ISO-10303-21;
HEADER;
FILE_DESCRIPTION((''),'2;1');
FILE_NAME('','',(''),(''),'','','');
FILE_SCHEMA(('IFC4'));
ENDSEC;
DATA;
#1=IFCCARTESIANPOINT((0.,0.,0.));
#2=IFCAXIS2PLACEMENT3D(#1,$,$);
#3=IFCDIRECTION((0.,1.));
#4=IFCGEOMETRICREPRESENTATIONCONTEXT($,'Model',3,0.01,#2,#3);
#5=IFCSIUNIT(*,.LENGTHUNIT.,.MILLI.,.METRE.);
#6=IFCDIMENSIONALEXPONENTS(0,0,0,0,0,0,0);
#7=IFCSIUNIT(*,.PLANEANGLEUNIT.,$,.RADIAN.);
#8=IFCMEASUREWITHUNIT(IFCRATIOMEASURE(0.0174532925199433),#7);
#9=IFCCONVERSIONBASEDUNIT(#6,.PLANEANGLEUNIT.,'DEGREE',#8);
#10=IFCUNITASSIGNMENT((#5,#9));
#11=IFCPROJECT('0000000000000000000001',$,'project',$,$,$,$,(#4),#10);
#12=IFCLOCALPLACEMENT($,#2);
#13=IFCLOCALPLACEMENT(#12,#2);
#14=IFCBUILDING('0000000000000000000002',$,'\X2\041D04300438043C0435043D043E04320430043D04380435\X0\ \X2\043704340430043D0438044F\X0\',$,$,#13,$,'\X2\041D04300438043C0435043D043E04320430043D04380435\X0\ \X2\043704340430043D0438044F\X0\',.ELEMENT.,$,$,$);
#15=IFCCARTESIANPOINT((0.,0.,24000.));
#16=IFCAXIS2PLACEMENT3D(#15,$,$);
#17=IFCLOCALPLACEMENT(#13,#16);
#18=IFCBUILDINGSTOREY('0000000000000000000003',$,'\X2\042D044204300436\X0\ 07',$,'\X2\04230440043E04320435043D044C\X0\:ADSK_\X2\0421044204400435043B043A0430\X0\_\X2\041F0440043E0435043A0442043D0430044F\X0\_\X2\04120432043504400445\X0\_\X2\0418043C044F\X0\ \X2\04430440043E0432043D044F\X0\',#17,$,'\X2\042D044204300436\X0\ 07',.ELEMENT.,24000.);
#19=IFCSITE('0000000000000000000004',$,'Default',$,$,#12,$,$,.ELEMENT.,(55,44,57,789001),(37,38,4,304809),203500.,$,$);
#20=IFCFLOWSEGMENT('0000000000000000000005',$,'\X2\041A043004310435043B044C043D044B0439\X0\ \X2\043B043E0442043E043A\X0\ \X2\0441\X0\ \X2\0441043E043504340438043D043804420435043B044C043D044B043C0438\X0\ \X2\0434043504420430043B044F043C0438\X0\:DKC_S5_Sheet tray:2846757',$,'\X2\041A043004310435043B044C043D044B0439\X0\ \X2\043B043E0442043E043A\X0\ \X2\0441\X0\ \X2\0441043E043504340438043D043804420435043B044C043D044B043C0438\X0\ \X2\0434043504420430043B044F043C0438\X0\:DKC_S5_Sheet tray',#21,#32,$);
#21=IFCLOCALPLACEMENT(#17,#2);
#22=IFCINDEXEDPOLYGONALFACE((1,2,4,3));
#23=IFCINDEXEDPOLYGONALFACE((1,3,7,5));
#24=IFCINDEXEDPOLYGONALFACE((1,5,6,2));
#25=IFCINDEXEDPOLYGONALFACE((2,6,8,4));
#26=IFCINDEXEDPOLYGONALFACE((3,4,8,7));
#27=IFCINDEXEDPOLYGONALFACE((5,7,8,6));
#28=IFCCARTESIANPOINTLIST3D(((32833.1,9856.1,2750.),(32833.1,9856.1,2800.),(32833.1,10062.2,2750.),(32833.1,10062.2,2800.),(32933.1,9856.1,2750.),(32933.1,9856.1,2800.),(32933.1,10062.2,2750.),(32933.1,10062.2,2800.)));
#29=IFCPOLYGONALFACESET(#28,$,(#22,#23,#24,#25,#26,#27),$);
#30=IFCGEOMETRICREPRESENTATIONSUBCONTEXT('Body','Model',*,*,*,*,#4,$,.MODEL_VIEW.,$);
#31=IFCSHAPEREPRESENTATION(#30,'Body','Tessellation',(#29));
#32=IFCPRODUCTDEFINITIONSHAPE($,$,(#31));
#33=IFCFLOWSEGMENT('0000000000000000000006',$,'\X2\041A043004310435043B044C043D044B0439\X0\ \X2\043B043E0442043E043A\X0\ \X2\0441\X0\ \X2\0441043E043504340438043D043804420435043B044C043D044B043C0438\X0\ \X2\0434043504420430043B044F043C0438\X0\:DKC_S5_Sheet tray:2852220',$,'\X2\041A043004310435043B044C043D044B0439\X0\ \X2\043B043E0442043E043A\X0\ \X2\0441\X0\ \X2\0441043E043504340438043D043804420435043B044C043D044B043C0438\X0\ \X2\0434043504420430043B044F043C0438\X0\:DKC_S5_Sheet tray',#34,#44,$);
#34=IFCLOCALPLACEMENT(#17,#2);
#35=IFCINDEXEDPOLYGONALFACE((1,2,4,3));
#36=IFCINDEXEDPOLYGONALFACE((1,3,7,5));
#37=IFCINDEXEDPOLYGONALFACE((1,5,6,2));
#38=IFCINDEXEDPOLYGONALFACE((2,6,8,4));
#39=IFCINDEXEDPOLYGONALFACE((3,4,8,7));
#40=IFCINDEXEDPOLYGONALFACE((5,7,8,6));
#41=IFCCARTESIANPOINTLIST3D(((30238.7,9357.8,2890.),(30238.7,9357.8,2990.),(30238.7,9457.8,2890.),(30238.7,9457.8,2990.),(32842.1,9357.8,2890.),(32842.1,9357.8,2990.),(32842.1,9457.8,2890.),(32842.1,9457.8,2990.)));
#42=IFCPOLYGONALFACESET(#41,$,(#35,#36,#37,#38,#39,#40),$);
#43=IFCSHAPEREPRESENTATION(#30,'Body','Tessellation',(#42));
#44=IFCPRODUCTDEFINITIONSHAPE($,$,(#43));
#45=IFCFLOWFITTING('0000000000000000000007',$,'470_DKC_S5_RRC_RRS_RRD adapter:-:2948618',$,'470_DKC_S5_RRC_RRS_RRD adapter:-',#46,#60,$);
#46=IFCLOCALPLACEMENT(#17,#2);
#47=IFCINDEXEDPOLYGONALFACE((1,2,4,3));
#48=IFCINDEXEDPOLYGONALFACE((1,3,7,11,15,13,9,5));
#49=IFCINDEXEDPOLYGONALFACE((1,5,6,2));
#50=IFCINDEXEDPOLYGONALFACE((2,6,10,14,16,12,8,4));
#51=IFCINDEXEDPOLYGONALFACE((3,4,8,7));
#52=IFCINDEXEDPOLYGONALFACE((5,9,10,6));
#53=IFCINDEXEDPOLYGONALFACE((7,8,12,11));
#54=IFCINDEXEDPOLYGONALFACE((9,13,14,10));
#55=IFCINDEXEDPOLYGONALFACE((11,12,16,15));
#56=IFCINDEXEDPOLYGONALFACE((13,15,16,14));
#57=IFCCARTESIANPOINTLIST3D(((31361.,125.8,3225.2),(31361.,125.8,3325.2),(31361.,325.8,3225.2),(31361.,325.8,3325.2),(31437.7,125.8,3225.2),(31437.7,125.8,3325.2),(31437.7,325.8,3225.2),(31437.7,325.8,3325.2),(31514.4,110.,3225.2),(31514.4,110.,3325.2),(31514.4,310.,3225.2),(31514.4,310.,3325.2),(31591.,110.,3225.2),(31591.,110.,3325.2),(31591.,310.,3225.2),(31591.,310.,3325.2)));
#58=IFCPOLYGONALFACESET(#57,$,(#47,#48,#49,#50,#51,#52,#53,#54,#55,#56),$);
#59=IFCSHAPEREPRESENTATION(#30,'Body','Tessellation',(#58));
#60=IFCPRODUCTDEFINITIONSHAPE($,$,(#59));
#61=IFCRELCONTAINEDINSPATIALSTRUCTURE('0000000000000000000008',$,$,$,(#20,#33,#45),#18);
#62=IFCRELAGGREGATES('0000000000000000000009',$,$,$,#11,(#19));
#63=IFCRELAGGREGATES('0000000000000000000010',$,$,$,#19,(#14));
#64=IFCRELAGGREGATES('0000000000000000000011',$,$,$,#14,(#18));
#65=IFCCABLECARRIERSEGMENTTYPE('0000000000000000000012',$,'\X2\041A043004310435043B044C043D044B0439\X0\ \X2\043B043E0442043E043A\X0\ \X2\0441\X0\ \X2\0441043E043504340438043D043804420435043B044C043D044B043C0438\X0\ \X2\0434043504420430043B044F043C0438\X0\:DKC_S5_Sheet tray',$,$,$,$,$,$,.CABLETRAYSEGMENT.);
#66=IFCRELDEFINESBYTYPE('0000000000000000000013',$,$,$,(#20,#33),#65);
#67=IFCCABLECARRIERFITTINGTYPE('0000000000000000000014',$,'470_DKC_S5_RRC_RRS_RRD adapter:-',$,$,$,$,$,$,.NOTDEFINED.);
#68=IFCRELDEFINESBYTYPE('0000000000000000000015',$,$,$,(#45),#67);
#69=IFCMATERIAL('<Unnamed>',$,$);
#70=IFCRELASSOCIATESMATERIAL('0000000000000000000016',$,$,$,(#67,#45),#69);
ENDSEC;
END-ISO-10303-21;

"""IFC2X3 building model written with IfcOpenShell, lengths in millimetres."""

from ifc_helpers import new_model, entity, si_unit, converted_unit, direction, frame, frame_2d, origin, place, context, subcontext, project, spatial, polyline, rectangle, outline, extrude, source, transform, mapped, material, type_object, type_shapes, element, save


model = new_model("IFC2X3")

# Units and contexts
model_context = context("Model", 3, precision=0.01, world=origin(), true_north=direction((0.0, 1.0)))
body_context = subcontext(model_context, "Body", "Model", "MODEL_VIEW")
ifc_project = project(units=[si_unit("LENGTHUNIT", "METRE", prefix="MILLI"), converted_unit("PLANEANGLEUNIT", "DEGREE", entity("IfcRatioMeasure", 0.0174532925199433), si_unit("PLANEANGLEUNIT", "RADIAN"), dimensions=[0, 0, 0, 0, 0, 0, 0])], contexts=[model_context])

# Site, building, storey
site_placement = place(None, frame((0.0, 0.0, 0.0)))
site = spatial("IfcSite", under=ifc_project, at=site_placement, Name="Default", CompositionType="ELEMENT", RefLatitude=(55, 44, 57, 789001), RefLongitude=(37, 38, 4, 304809), RefElevation=203500.0)
building_placement = place(site_placement, origin())
building = spatial("IfcBuilding", under=site, at=building_placement, Name="Наименование здания", LongName="Наименование здания", CompositionType="ELEMENT")
storey_placement = place(building_placement, frame((0.0, 0.0, 24000.0)))
storey = spatial("IfcBuildingStorey", under=building, at=storey_placement, Name="Этаж 07", ObjectType="Уровень:ADSK_Стрелка_Проектная_Вверх_Имя уровня", LongName="Этаж 07", CompositionType="ELEMENT", Elevation=24000.0)

# Flow segments
cable_carrier_segment_type = type_object("IfcCableCarrierSegmentType", Name="Кабельный лоток с соединительными деталями:DKC_S5_Sheet tray", PredefinedType="CABLETRAYSEGMENT")
flow_segment_1_placement = place(storey_placement, frame((32833.1, 9856.1, 2750.0)))
element("IfcFlowSegment", 1, at=flow_segment_1_placement, inside=storey, type_object=cable_carrier_segment_type, Name="Кабельный лоток с соединительными деталями:DKC_S5_Sheet tray:2846757", ObjectType="Кабельный лоток с соединительными деталями:DKC_S5_Sheet tray", context=body_context, shape_type="SweptSolid", body=[
    extrude(rectangle(XDim=206.1, YDim=100.0, at=frame_2d((0.0, 0.0), x_axis=(1.0, 0.0))), frame((50.0, 103.0, 0.0), z_axis=(0.0, 0.0, 1.0), x_axis=(0.0, -1.0, 0.0)), (0.0, 0.0, 1.0), 50.0),
])
flow_segment_2_placement = place(storey_placement, frame((30238.7, 9357.8, 2890.0)))
element("IfcFlowSegment", 2, at=flow_segment_2_placement, inside=storey, type_object=cable_carrier_segment_type, Name="Кабельный лоток с соединительными деталями:DKC_S5_Sheet tray:2852220", ObjectType="Кабельный лоток с соединительными деталями:DKC_S5_Sheet tray", context=body_context, shape_type="SweptSolid", body=[
    extrude(rectangle(XDim=2603.4, YDim=100.0, at=frame_2d((0.0, 0.0), x_axis=(1.0, 0.0))), frame((1301.7, 50.0, 0.0)), (0.0, 0.0, 1.0), 100.0),
])

# Flow fitting
ifc_material = material(Name="<Unnamed>")
cable_carrier_fitting_type_1 = type_object("IfcCableCarrierFittingType", Name="470_DKC_S5_RRC_RRS_RRD adapter:-", PredefinedType="NOTDEFINED", material=ifc_material)
shared_shape_1 = source(origin(), body_context, "Body", "SweptSolid", [
    extrude(outline(polyline([(-115.0, 92.1), (-115.0, -107.9), (-38.3, -107.9), (38.3, -92.1), (115.0, -92.1), (115.0, 107.9), (38.3, 107.9), (-38.3, 92.1), (-115.0, 92.1)])), frame((115.0, -7.9, -50.0), z_axis=(0.0, 0.0, -1.0), x_axis=(1.0, 0.0, 0.0)), (0.0, 0.0, -1.0), 100.0),
])
type_shapes(cable_carrier_fitting_type_1, [shared_shape_1])
flow_fitting_1_placement = place(storey_placement, frame((31591.0, 210.0, 3275.2), z_axis=(0.0, 0.0, 1.0), x_axis=(-1.0, 0.0, 0.0)))
element("IfcFlowFitting", 3, at=flow_fitting_1_placement, inside=storey, type_object=cable_carrier_fitting_type_1, material=ifc_material, Name="470_DKC_S5_RRC_RRS_RRD adapter:-:2948618", ObjectType="470_DKC_S5_RRC_RRS_RRD adapter:-", context=body_context, shape_type="MappedRepresentation", body=[
    mapped(shared_shape_1, transform((0.0, 0.0, 0.0), scale=1.0)),
])

save(model, "model.ifc")
